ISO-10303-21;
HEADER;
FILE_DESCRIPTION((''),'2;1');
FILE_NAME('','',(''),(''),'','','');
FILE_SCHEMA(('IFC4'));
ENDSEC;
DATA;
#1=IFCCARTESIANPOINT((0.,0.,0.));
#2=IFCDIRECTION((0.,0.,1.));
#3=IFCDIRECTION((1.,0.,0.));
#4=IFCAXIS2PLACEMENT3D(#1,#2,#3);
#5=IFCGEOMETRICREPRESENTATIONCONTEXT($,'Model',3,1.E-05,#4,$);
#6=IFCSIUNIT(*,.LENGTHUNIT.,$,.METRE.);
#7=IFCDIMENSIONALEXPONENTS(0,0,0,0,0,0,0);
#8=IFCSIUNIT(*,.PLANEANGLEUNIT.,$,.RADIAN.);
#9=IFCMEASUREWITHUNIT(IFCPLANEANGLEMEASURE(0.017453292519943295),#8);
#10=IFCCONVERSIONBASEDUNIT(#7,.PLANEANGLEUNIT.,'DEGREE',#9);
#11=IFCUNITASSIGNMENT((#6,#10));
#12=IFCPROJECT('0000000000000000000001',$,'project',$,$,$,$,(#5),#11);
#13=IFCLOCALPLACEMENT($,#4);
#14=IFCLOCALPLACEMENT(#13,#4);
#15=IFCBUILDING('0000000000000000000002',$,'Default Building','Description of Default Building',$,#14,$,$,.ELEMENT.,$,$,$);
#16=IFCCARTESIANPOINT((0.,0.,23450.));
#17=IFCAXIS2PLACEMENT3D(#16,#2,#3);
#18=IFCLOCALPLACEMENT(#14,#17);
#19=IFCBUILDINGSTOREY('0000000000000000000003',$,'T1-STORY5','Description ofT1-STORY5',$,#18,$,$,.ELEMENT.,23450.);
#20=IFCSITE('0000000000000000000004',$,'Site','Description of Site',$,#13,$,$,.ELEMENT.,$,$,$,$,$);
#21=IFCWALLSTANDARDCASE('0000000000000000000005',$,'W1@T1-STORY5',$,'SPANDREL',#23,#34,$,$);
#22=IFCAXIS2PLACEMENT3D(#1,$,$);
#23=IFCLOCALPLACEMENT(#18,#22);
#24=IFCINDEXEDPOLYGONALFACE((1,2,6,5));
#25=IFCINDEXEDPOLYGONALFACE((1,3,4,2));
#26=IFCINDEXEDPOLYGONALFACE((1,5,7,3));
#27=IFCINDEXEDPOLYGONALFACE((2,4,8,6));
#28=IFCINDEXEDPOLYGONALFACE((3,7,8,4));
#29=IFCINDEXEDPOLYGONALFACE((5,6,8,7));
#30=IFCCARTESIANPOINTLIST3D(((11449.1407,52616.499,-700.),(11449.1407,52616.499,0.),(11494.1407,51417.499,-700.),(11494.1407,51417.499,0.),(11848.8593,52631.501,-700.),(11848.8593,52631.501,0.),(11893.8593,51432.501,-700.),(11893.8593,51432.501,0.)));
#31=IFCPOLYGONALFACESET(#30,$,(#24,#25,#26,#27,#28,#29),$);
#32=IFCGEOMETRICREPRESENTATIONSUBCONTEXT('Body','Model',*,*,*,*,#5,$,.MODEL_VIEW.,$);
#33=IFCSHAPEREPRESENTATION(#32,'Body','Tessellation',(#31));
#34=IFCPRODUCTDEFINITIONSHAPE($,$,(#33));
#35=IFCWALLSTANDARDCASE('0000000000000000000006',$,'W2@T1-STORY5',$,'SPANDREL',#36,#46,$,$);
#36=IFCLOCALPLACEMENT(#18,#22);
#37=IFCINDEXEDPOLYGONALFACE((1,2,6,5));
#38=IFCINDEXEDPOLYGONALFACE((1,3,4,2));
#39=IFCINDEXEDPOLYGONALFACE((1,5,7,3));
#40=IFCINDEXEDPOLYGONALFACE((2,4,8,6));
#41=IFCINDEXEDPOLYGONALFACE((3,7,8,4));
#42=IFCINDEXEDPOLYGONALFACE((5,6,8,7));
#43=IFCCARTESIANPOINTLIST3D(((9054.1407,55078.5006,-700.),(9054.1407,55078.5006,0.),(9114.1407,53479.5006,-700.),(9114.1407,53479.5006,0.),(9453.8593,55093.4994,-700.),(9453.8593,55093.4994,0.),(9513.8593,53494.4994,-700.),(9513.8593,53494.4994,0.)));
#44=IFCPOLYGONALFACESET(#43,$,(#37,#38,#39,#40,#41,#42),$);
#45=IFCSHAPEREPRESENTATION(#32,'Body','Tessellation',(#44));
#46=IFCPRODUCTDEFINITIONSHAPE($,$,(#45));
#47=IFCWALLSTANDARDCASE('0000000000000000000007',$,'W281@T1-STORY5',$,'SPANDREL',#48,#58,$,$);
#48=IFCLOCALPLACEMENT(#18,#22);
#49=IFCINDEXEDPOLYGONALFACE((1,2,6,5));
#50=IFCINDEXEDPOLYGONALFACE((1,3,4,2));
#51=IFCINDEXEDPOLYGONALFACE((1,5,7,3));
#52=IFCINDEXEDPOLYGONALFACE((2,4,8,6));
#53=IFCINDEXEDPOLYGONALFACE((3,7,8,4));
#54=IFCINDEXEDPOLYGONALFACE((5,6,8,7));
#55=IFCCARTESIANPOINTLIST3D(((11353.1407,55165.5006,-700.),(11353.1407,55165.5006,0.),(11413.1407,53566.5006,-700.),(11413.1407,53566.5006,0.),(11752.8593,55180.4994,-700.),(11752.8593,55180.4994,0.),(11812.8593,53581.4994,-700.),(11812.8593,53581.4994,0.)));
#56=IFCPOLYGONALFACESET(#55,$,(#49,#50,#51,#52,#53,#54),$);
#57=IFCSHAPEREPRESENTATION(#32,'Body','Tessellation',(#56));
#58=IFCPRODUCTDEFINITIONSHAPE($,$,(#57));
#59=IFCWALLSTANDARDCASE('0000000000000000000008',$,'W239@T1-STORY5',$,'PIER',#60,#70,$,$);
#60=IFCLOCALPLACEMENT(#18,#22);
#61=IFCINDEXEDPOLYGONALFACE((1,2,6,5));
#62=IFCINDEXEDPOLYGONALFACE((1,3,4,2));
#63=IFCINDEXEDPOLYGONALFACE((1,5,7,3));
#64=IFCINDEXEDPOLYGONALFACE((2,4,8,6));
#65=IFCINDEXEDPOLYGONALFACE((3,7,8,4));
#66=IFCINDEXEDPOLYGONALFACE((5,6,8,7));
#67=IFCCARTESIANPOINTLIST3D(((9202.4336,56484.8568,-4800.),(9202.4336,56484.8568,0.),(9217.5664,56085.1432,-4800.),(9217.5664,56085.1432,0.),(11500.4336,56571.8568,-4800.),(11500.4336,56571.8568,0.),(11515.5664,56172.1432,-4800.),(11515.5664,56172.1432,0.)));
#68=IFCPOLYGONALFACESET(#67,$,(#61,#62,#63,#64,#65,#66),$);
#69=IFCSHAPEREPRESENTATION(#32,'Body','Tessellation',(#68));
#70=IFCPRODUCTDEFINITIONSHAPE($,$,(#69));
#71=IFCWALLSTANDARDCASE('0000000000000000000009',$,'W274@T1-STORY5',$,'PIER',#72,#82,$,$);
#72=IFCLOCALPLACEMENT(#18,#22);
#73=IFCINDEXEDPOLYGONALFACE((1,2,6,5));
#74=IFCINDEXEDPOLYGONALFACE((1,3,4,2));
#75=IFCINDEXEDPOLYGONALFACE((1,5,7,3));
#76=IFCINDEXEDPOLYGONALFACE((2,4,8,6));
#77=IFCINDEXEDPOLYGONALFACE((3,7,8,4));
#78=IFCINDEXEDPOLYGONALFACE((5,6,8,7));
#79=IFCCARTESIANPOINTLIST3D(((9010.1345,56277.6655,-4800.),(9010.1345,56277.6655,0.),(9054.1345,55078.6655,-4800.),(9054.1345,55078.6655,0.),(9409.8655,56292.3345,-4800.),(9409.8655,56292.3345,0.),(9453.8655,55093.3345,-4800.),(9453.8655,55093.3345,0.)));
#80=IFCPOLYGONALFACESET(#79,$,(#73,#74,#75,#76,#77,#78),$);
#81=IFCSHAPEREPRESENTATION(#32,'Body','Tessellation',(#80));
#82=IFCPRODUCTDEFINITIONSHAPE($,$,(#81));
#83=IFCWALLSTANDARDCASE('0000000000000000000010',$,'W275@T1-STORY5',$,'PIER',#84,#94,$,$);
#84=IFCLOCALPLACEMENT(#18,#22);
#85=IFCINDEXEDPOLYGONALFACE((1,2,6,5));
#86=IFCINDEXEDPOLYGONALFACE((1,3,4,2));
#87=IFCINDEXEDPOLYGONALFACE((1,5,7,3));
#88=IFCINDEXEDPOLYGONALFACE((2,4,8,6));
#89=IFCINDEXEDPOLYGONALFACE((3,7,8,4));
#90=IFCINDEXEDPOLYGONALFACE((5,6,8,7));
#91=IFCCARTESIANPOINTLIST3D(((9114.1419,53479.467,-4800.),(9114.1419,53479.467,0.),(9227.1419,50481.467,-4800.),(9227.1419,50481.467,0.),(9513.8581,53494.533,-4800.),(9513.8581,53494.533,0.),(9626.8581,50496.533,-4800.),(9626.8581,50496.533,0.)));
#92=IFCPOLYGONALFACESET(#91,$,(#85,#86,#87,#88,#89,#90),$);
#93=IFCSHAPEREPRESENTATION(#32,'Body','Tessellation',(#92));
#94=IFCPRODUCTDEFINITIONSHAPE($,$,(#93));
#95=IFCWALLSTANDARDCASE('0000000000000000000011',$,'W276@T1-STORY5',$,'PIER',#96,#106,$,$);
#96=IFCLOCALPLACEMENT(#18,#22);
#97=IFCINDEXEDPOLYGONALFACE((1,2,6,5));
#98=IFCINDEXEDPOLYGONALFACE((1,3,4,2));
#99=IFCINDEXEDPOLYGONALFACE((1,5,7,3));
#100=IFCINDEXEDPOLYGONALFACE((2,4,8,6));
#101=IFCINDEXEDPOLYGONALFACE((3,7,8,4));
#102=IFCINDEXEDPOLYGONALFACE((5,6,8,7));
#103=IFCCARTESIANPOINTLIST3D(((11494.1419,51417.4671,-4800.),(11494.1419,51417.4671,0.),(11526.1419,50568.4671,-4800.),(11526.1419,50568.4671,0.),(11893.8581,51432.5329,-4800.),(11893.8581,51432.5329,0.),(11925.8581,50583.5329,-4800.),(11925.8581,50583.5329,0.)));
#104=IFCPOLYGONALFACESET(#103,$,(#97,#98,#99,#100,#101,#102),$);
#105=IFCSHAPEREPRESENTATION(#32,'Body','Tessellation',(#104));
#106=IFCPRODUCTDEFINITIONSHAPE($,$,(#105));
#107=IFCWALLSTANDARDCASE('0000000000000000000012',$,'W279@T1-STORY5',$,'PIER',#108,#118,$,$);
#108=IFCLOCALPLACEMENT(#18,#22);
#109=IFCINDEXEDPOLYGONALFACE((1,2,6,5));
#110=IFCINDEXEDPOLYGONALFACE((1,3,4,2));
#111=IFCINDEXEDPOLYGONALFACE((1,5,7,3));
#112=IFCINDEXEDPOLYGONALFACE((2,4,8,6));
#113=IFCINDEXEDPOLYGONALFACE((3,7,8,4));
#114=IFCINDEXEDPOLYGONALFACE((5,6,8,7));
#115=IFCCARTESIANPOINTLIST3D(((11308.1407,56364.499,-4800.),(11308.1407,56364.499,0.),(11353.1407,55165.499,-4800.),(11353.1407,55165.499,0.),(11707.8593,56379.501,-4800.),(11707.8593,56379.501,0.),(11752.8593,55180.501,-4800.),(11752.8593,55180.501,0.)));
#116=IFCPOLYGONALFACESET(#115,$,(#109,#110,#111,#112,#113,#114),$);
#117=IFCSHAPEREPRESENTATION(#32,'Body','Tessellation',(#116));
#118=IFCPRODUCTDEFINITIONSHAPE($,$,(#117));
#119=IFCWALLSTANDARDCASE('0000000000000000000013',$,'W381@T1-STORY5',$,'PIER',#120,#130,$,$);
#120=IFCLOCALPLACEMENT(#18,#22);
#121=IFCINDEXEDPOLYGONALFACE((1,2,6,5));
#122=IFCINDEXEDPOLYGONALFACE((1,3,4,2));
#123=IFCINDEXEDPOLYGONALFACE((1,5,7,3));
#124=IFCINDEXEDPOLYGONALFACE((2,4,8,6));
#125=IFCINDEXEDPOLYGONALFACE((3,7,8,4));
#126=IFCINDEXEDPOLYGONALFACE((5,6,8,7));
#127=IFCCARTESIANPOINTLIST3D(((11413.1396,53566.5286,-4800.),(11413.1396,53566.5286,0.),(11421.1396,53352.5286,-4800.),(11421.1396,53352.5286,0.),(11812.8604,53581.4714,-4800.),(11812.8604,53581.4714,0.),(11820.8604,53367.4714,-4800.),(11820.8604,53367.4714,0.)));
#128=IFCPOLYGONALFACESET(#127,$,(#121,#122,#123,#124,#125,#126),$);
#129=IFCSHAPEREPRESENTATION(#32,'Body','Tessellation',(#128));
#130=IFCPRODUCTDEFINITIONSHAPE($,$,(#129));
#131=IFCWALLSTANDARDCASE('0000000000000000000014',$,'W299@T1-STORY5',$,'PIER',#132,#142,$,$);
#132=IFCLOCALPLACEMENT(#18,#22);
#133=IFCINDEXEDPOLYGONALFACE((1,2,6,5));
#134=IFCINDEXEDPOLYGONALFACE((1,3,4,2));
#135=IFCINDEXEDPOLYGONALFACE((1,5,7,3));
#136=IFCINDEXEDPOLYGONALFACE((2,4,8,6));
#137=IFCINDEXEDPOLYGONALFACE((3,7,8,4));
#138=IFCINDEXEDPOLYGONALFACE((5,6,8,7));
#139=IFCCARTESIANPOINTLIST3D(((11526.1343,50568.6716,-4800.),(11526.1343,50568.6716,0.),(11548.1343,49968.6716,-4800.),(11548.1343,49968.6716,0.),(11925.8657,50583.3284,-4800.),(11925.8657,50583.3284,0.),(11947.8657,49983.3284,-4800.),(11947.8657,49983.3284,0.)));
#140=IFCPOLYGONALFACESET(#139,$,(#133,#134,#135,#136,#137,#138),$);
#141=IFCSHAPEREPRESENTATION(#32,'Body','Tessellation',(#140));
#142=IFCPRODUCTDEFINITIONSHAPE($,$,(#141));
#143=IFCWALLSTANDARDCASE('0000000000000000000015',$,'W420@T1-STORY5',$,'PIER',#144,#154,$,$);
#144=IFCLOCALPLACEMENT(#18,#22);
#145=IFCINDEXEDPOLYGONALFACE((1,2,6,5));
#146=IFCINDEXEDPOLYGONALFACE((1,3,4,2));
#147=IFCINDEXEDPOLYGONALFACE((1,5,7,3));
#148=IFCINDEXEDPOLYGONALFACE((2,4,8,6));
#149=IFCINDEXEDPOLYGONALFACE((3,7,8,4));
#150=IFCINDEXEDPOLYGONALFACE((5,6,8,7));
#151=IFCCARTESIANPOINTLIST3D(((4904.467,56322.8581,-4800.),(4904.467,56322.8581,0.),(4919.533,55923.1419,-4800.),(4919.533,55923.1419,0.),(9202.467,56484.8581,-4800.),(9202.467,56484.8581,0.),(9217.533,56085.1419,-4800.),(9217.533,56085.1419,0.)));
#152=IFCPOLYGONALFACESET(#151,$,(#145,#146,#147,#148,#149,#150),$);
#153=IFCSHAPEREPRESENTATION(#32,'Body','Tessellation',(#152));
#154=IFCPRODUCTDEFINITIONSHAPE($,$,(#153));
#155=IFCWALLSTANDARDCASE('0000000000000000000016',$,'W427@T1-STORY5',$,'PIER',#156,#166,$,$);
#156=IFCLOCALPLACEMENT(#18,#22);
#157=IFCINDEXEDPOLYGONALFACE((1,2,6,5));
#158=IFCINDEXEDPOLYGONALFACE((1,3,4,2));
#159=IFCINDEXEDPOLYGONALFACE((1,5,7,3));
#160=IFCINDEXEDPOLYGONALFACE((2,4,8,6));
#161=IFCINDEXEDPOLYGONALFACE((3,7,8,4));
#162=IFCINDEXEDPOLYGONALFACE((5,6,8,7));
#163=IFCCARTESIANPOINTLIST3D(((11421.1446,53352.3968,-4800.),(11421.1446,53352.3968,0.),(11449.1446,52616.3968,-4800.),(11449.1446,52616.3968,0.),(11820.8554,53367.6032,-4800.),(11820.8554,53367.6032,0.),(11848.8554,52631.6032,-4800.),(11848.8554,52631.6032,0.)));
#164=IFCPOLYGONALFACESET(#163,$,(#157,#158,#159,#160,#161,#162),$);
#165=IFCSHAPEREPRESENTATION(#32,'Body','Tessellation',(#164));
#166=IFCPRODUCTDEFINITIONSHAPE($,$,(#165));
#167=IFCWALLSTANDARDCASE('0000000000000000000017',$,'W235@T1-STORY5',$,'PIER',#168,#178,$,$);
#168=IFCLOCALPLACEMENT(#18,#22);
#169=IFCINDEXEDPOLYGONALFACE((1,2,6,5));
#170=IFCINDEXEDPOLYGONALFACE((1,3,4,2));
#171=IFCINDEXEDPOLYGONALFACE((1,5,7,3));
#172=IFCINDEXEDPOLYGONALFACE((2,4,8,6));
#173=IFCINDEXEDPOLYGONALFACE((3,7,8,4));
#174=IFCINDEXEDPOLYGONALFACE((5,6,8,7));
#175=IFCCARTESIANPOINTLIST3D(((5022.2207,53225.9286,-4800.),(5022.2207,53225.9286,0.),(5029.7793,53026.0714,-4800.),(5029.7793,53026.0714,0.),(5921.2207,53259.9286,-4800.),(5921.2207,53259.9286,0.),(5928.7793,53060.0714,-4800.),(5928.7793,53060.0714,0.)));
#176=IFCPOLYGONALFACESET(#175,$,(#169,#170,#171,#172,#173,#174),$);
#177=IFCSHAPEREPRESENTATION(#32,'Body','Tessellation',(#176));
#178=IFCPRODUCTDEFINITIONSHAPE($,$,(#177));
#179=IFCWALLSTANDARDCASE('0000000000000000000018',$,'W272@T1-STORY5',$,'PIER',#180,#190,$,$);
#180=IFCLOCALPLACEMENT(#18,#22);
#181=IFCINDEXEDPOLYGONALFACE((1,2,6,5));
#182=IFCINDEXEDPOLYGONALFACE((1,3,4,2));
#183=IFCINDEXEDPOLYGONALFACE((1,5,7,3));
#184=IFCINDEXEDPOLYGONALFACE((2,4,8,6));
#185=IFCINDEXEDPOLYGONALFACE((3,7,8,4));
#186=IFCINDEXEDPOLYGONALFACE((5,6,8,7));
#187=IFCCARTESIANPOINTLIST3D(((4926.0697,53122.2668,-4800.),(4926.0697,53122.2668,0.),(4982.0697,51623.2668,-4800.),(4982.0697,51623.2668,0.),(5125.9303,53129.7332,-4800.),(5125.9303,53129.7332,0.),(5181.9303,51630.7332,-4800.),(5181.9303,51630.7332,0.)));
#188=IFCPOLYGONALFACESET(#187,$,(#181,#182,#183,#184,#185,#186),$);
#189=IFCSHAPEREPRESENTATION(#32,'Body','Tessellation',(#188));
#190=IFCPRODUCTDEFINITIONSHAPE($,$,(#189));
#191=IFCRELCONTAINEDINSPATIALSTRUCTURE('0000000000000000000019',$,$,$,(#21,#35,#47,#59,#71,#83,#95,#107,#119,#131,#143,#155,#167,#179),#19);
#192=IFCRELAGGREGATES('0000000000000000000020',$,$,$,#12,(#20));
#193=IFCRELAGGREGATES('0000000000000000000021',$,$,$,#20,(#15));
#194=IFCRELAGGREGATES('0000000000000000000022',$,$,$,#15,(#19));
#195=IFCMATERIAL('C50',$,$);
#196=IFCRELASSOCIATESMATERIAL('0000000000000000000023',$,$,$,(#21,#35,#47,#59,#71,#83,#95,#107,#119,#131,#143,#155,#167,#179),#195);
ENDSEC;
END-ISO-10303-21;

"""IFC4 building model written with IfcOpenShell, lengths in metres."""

from ifc_helpers import new_model, entity, si_unit, converted_unit, frame, origin_with_axes, place, context, subcontext, project, spatial, indexed_curve, outline, extrude, material, element, save


model = new_model("IFC4")

# Units and contexts
model_context = context("Model", 3, precision=1e-05, world=origin_with_axes())
body_context = subcontext(model_context, "Body", "Model", "MODEL_VIEW")
ifc_project = project(units=[si_unit("LENGTHUNIT", "METRE"), converted_unit("PLANEANGLEUNIT", "DEGREE", entity("IfcPlaneAngleMeasure", 0.017453292519943295), si_unit("PLANEANGLEUNIT", "RADIAN"), dimensions=[0, 0, 0, 0, 0, 0, 0])], contexts=[model_context])

# Site, building, storey
site_placement = place(None, origin_with_axes())
site = spatial("IfcSite", under=ifc_project, at=site_placement, Name="Site", Description="Description of Site", CompositionType="ELEMENT")
building_placement = place(site_placement, origin_with_axes())
building = spatial("IfcBuilding", under=site, at=building_placement, Name="Default Building", Description="Description of Default Building", CompositionType="ELEMENT")
storey_placement = place(building_placement, frame((0.0, 0.0, 23450.0), z_axis=(0.0, 0.0, 1.0), x_axis=(1.0, 0.0, 0.0)))
storey = spatial("IfcBuildingStorey", under=building, at=storey_placement, Name="T1-STORY5", Description="Description ofT1-STORY5", CompositionType="ELEMENT", Elevation=23450.0)

# Shared definitions
ifc_material_1 = material(Name="C50")

# Walls
wall_1_placement = place(storey_placement, frame((11649.0, 52624.0, -700.0), z_axis=(0.0, 0.0, 1.0), x_axis=(0.037505, -0.999296, 0.0)))
element("IfcWallStandardCase", 1, at=wall_1_placement, inside=storey, material=ifc_material_1, Name="W1@T1-STORY5", ObjectType="SPANDREL", context=body_context, shape_type="SweptSolid", body=[
    extrude(outline(indexed_curve([(0.0, -200.0), (0.0, 200.0), (1199.8442, 200.0), (1199.8442, -200.0), (0.0, -200.0)], self_intersect=False)), origin_with_axes(), (0.0, 0.0, 1.0), 700.0),
])
for number, where, z_axis, x_axis, name in (
    (2, (9254.0, 55086.0, -700.0), (0.0, 0.0, 1.0), (0.037497, -0.999297, 0.0), "W2@T1-STORY5"),
    (3, (11553.0, 55173.0, -700.0), (0.0, 0.0, 1.0), (0.037497, -0.999297, 0.0), "W281@T1-STORY5"),
):
    element("IfcWallStandardCase", number, at=place(storey_placement, frame(where, z_axis=z_axis, x_axis=x_axis)), inside=storey, material=ifc_material_1, Name=name, ObjectType="SPANDREL", context=body_context, shape_type="SweptSolid", body=[
        extrude(outline(indexed_curve([(0.0, -200.0), (0.0, 200.0), (1600.1253, 200.0), (1600.1253, -200.0), (0.0, -200.0)], self_intersect=False)), origin_with_axes(), (0.0, 0.0, 1.0), 700.0),
    ])
wall_2_placement = place(storey_placement, frame((9210.0, 56285.0, -4800.0), z_axis=(0.0, 0.0, 1.0), x_axis=(0.999284, 0.037832, 0.0)))
element("IfcWallStandardCase", 4, at=wall_2_placement, inside=storey, material=ifc_material_1, Name="W239@T1-STORY5", ObjectType="PIER", context=body_context, shape_type="SweptSolid", body=[
    extrude(outline(indexed_curve([(0.0, -200.0), (0.0, 200.0), (2299.6463, 200.0), (2299.6463, -200.0), (0.0, -200.0)], self_intersect=False)), origin_with_axes(), (0.0, 0.0, 1.0), 4800.0),
])
wall_3_placement = place(storey_placement, frame((9210.0, 56285.0, -4800.0), z_axis=(0.0, 0.0, 1.0), x_axis=(0.036673, -0.999327, 0.0)))
element("IfcWallStandardCase", 5, at=wall_3_placement, inside=storey, material=ifc_material_1, Name="W274@T1-STORY5", ObjectType="PIER", context=body_context, shape_type="SweptSolid", body=[
    extrude(outline(indexed_curve([(0.0, -200.0), (0.0, 200.0), (1199.8071, 200.0), (1199.8071, -200.0), (0.0, -200.0)], self_intersect=False)), origin_with_axes(), (0.0, 0.0, 1.0), 4800.0),
])
wall_4_placement = place(storey_placement, frame((9314.0, 53487.0, -4800.0), z_axis=(0.0, 0.0, 1.0), x_axis=(0.037665, -0.99929, 0.0)))
element("IfcWallStandardCase", 6, at=wall_4_placement, inside=storey, material=ifc_material_1, Name="W275@T1-STORY5", ObjectType="PIER", context=body_context, shape_type="SweptSolid", body=[
    extrude(outline(indexed_curve([(0.0, -200.0), (0.0, 200.0), (3000.1288, 200.0), (3000.1288, -200.0), (0.0, -200.0)], self_intersect=False)), origin_with_axes(), (0.0, 0.0, 1.0), 4800.0),
])
wall_5_placement = place(storey_placement, frame((11694.0, 51425.0, -4800.0), z_axis=(0.0, 0.0, 1.0), x_axis=(0.037665, -0.99929, 0.0)))
element("IfcWallStandardCase", 7, at=wall_5_placement, inside=storey, material=ifc_material_1, Name="W276@T1-STORY5", ObjectType="PIER", context=body_context, shape_type="SweptSolid", body=[
    extrude(outline(indexed_curve([(0.0, -200.0), (0.0, 200.0), (849.6028, 200.0), (849.6028, -200.0), (0.0, -200.0)], self_intersect=False)), origin_with_axes(), (0.0, 0.0, 1.0), 4800.0),
])
wall_6_placement = place(storey_placement, frame((11508.0, 56372.0, -4800.0), z_axis=(0.0, 0.0, 1.0), x_axis=(0.037505, -0.999296, 0.0)))
element("IfcWallStandardCase", 8, at=wall_6_placement, inside=storey, material=ifc_material_1, Name="W279@T1-STORY5", ObjectType="PIER", context=body_context, shape_type="SweptSolid", body=[
    extrude(outline(indexed_curve([(0.0, -200.0), (0.0, 200.0), (1199.8442, 200.0), (1199.8442, -200.0), (0.0, -200.0)], self_intersect=False)), origin_with_axes(), (0.0, 0.0, 1.0), 4800.0),
])
wall_7_placement = place(storey_placement, frame((11613.0, 53574.0, -4800.0), z_axis=(0.0, 0.0, 1.0), x_axis=(0.037357, -0.999302, 0.0)))
element("IfcWallStandardCase", 9, at=wall_7_placement, inside=storey, material=ifc_material_1, Name="W381@T1-STORY5", ObjectType="PIER", context=body_context, shape_type="SweptSolid", body=[
    extrude(outline(indexed_curve([(0.0, -200.0), (0.0, 200.0), (214.1495, 200.0), (214.1495, -200.0), (0.0, -200.0)], self_intersect=False)), origin_with_axes(), (0.0, 0.0, 1.0), 4800.0),
])
wall_8_placement = place(storey_placement, frame((11726.0, 50576.0, -4800.0), z_axis=(0.0, 0.0, 1.0), x_axis=(0.036642, -0.999328, 0.0)))
element("IfcWallStandardCase", 10, at=wall_8_placement, inside=storey, material=ifc_material_1, Name="W299@T1-STORY5", ObjectType="PIER", context=body_context, shape_type="SweptSolid", body=[
    extrude(outline(indexed_curve([(0.0, -200.0), (0.0, 200.0), (600.4032, 200.0), (600.4032, -200.0), (0.0, -200.0)], self_intersect=False)), origin_with_axes(), (0.0, 0.0, 1.0), 4800.0),
])
wall_9_placement = place(storey_placement, frame((4912.0, 56123.0, -4800.0), z_axis=(0.0, 0.0, 1.0), x_axis=(0.99929, 0.037665, 0.0)))
element("IfcWallStandardCase", 11, at=wall_9_placement, inside=storey, material=ifc_material_1, Name="W420@T1-STORY5", ObjectType="PIER", context=body_context, shape_type="SweptSolid", body=[
    extrude(outline(indexed_curve([(0.0, -200.0), (0.0, 200.0), (4301.052, 200.0), (4301.052, -200.0), (0.0, -200.0)], self_intersect=False)), origin_with_axes(), (0.0, 0.0, 1.0), 4800.0),
])
wall_10_placement = place(storey_placement, frame((11621.0, 53360.0, -4800.0), z_axis=(0.0, 0.0, 1.0), x_axis=(0.038016, -0.999277, 0.0)))
element("IfcWallStandardCase", 12, at=wall_10_placement, inside=storey, material=ifc_material_1, Name="W427@T1-STORY5", ObjectType="PIER", context=body_context, shape_type="SweptSolid", body=[
    extrude(outline(indexed_curve([(0.0, -200.0), (0.0, 200.0), (736.5324, 200.0), (736.5324, -200.0), (0.0, -200.0)], self_intersect=False)), origin_with_axes(), (0.0, 0.0, 1.0), 4800.0),
])
wall_11_placement = place(storey_placement, frame((5026.0, 53126.0, -4800.0), z_axis=(0.0, 0.0, 1.0), x_axis=(0.999286, 0.037793, 0.0)))
element("IfcWallStandardCase", 13, at=wall_11_placement, inside=storey, material=ifc_material_1, Name="W235@T1-STORY5", ObjectType="PIER", context=body_context, shape_type="SweptSolid", body=[
    extrude(outline(indexed_curve([(0.0, -100.0), (0.0, 100.0), (899.6427, 100.0), (899.6427, -100.0), (0.0, -100.0)], self_intersect=False)), origin_with_axes(), (0.0, 0.0, 1.0), 4800.0),
])
wall_12_placement = place(storey_placement, frame((5026.0, 53126.0, -4800.0), z_axis=(0.0, 0.0, 1.0), x_axis=(0.037332, -0.999303, 0.0)))
element("IfcWallStandardCase", 14, at=wall_12_placement, inside=storey, material=ifc_material_1, Name="W272@T1-STORY5", ObjectType="PIER", context=body_context, shape_type="SweptSolid", body=[
    extrude(outline(indexed_curve([(0.0, -100.0), (0.0, 100.0), (1500.0457, 100.0), (1500.0457, -100.0), (0.0, -100.0)], self_intersect=False)), origin_with_axes(), (0.0, 0.0, 1.0), 4800.0),
])

save(model, "model.ifc")
